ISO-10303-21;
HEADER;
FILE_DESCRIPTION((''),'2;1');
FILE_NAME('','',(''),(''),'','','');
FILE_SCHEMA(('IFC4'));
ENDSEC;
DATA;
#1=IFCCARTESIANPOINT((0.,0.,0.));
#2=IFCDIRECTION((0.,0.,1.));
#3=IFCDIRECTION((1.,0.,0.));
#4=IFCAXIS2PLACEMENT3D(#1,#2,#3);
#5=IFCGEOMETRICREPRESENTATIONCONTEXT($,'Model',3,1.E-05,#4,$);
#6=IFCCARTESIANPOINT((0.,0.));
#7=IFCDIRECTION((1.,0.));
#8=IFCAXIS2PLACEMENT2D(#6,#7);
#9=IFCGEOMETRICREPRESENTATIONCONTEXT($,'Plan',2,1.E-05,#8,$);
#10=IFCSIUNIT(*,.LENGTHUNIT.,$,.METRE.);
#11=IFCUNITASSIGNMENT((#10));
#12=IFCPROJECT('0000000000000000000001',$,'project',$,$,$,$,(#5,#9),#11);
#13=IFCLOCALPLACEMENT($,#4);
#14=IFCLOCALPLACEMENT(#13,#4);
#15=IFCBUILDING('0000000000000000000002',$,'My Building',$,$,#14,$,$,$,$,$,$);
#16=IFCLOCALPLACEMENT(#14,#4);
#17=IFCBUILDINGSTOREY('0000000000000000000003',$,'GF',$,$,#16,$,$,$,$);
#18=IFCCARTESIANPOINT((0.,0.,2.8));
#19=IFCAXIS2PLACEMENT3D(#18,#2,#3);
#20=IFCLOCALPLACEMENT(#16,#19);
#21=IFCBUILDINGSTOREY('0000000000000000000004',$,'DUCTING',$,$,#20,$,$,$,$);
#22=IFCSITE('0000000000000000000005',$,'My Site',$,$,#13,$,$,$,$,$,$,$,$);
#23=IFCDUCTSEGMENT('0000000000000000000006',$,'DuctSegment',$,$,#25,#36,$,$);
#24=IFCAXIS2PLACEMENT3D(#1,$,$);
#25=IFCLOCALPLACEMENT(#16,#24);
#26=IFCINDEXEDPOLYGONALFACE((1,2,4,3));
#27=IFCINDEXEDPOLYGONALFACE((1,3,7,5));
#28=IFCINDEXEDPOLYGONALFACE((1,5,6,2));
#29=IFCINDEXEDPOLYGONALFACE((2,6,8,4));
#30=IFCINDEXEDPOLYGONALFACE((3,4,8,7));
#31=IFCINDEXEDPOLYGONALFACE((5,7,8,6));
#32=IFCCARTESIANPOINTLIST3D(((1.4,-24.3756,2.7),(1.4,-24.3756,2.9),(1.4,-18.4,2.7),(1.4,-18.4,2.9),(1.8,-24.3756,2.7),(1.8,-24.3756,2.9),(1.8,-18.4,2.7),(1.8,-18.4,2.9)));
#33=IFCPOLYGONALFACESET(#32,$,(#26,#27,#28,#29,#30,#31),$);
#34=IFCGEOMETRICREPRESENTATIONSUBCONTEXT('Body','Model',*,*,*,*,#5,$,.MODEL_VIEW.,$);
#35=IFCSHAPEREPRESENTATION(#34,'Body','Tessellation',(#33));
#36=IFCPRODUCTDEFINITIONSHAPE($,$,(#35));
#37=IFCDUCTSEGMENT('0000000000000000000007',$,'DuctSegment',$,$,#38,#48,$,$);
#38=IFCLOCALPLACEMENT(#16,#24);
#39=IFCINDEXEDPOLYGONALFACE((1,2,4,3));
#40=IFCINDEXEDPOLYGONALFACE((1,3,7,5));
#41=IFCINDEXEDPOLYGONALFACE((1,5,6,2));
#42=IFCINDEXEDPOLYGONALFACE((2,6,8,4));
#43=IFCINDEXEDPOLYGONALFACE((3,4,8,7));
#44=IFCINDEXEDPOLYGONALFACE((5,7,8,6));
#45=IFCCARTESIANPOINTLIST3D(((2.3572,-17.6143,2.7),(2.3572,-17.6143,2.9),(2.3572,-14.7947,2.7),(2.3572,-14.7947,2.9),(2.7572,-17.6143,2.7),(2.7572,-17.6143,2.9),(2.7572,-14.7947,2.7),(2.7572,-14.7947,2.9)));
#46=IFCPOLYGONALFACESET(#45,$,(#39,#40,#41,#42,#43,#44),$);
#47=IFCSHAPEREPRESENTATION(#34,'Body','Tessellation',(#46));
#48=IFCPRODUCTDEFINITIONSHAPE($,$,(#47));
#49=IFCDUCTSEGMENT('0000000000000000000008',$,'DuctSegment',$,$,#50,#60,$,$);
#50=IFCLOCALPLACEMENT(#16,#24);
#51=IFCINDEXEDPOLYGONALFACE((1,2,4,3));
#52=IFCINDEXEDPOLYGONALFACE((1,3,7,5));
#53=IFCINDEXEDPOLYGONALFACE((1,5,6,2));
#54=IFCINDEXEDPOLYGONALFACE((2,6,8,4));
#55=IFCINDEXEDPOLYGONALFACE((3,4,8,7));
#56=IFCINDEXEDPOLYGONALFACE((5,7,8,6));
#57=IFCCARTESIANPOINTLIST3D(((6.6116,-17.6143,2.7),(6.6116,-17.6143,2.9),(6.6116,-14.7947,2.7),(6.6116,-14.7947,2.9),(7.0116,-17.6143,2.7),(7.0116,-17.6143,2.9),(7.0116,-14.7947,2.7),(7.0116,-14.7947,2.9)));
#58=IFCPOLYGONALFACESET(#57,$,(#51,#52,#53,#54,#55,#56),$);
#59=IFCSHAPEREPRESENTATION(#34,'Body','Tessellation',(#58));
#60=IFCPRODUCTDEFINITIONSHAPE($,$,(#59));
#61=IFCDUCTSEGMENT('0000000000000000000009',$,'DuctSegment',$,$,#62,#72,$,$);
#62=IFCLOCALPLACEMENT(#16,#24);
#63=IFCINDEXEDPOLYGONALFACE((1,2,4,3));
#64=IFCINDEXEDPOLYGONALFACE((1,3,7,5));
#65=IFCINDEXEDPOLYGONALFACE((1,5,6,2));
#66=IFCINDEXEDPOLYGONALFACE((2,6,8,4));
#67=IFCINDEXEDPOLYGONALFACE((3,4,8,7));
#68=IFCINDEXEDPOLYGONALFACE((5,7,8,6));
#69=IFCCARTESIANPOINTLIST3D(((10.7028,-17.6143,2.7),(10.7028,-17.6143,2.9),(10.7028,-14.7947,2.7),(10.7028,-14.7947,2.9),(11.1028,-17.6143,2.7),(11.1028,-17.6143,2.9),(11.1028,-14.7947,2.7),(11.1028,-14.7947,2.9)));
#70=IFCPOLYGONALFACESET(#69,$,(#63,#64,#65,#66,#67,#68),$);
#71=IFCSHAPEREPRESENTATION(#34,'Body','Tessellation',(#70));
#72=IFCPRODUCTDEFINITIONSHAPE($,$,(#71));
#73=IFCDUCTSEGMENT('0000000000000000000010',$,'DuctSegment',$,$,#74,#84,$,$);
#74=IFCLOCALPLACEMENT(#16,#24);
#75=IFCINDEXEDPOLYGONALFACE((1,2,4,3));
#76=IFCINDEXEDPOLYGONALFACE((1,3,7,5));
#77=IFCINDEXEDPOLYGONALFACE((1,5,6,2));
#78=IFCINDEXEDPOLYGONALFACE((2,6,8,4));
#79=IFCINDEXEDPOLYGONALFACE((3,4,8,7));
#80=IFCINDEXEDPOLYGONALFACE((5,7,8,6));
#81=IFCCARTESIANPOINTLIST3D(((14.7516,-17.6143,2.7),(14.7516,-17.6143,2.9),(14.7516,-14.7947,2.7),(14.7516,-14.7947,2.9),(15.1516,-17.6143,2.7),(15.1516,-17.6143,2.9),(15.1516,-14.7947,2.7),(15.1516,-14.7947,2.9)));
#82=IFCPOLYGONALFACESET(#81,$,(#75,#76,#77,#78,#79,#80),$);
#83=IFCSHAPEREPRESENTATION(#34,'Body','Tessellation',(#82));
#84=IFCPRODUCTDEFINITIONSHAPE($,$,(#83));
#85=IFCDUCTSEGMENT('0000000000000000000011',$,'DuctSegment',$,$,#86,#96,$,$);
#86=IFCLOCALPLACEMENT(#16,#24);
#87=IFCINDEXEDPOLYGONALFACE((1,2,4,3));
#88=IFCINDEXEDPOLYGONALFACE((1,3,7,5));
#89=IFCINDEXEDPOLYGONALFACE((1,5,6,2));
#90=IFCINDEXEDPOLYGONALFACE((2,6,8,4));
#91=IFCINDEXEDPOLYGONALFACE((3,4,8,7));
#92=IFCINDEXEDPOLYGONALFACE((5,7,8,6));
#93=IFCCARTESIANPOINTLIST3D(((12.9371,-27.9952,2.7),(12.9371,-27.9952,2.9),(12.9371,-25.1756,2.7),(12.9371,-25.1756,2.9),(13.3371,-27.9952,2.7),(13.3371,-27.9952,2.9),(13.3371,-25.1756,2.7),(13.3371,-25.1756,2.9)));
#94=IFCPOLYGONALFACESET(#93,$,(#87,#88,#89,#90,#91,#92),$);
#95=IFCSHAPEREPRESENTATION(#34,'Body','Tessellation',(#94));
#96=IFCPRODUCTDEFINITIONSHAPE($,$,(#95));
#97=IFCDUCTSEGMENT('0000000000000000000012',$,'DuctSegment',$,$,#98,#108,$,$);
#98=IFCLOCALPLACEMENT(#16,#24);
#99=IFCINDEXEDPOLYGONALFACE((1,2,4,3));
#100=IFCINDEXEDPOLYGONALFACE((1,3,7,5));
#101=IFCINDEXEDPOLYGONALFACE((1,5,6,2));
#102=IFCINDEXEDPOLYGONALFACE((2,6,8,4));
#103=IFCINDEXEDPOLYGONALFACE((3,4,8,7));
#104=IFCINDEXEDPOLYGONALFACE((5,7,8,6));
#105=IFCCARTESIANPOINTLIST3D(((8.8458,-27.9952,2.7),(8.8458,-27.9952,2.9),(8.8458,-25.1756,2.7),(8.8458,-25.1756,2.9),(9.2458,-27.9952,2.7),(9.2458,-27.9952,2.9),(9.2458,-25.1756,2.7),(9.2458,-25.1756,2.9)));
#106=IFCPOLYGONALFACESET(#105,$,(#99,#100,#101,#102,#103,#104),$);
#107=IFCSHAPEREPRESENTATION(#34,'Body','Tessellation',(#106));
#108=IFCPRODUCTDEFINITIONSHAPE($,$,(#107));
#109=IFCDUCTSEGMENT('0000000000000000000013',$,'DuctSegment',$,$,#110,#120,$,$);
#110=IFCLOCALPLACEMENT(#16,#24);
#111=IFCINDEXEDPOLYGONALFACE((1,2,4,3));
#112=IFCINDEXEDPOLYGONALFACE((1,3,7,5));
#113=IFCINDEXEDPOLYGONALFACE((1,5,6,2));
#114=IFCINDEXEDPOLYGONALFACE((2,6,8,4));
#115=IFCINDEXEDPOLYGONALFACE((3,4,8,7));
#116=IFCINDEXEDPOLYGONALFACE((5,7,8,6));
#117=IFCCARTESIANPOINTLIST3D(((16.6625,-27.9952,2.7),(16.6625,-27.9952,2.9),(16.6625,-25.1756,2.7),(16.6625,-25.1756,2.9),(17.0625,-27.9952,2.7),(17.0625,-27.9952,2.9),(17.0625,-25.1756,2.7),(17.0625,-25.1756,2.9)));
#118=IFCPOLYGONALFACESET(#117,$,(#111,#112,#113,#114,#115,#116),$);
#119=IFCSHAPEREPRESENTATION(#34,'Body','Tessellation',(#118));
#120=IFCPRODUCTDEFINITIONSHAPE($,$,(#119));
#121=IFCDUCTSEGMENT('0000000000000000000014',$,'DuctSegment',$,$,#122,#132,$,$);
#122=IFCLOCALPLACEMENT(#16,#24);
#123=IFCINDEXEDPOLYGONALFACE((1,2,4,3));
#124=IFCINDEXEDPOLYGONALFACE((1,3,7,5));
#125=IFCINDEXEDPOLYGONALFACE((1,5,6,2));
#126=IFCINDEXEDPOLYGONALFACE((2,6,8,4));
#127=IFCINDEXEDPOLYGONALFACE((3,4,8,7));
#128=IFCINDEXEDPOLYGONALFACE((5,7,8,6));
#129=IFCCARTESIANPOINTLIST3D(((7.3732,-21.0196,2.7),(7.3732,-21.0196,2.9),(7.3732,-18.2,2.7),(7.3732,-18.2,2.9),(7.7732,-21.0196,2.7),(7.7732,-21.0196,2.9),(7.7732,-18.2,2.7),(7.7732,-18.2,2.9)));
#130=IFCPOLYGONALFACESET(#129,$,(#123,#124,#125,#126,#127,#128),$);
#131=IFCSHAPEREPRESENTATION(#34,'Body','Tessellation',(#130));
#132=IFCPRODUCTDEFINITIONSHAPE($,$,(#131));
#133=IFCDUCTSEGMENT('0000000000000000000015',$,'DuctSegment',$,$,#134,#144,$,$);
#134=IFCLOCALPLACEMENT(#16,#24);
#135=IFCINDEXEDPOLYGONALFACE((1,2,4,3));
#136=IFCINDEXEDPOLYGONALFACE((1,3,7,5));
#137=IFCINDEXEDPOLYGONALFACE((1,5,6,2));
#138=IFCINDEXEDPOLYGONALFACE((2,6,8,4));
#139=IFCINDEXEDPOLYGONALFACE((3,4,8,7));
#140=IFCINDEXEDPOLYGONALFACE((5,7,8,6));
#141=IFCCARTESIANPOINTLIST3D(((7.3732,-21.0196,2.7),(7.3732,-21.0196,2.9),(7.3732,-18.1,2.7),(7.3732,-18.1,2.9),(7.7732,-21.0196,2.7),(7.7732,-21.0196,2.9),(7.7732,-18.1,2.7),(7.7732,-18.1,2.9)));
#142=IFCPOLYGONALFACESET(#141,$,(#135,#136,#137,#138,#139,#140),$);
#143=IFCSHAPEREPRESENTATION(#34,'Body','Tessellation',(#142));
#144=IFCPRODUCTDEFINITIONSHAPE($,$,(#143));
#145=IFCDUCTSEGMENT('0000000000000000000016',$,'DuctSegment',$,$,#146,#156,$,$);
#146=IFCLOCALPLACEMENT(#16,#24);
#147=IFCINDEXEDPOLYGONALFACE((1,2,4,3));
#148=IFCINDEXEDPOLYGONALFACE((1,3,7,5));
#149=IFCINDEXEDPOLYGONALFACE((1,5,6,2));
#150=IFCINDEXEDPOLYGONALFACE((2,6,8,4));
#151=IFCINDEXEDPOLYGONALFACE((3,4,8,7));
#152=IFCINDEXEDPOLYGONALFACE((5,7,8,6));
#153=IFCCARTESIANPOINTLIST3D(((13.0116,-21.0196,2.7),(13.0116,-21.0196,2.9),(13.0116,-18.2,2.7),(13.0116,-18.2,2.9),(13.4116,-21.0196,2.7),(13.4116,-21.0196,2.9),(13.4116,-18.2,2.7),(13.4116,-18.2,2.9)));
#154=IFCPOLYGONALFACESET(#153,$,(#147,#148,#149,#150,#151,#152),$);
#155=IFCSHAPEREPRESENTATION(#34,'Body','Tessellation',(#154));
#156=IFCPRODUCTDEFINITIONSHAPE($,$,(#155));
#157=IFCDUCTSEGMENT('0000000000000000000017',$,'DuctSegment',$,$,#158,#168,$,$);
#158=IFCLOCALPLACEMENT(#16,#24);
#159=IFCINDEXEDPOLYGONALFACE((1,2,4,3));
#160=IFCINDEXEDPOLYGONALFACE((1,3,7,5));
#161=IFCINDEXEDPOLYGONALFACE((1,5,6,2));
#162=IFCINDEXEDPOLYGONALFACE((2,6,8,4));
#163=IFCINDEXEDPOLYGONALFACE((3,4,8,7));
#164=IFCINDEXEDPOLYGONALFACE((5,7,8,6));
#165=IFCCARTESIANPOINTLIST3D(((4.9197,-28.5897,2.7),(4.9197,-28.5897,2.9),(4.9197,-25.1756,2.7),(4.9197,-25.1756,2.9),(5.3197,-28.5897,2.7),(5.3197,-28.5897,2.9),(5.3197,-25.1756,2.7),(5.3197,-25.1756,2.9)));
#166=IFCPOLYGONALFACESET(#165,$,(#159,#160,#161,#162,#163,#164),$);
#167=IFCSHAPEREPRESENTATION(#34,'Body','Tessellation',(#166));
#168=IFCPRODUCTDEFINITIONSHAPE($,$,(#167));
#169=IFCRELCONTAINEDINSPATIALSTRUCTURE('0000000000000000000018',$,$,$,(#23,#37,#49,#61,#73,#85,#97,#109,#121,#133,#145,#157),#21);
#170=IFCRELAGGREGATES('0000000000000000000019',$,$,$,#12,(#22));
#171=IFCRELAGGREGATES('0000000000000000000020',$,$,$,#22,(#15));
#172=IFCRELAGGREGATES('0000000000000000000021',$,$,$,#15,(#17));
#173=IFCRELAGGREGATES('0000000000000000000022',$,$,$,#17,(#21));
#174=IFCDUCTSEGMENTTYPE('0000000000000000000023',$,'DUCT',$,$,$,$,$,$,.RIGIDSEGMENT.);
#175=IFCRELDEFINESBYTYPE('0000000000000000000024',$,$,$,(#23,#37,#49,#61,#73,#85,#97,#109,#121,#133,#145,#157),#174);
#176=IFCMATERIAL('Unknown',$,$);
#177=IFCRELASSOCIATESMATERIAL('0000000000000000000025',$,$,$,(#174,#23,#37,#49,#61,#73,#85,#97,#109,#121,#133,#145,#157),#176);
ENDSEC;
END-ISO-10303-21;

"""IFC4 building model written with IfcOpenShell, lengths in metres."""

from ifc_helpers import new_model, si_unit, frame, origin_with_axes, origin_2d_with_axis, place, context, subcontext, project, spatial, rectangle, extrude, material, material_profile, profile_set, profile_usage, type_object, element, save


model = new_model("IFC4")

# Units and contexts
model_context = context("Model", 3, precision=1e-05, world=origin_with_axes())
plan_context = context("Plan", 2, precision=1e-05, world=origin_2d_with_axis())
body_context = subcontext(model_context, "Body", "Model", "MODEL_VIEW")
ifc_project = project(units=[si_unit("LENGTHUNIT", "METRE")], contexts=[model_context, plan_context])

# Site, building, storeys
site_placement = place(None, origin_with_axes())
site = spatial("IfcSite", under=ifc_project, at=site_placement, Name="My Site")
building_placement = place(site_placement, origin_with_axes())
building = spatial("IfcBuilding", under=site, at=building_placement, Name="My Building")
storey_1_placement = place(building_placement, origin_with_axes())
storey_1 = spatial("IfcBuildingStorey", under=building, at=storey_1_placement, Name="GF")
storey_2_placement = place(storey_1_placement, frame((0.0, 0.0, 2.8), z_axis=(0.0, 0.0, 1.0), x_axis=(1.0, 0.0, 0.0)))
storey_2 = spatial("IfcBuildingStorey", under=storey_1, at=storey_2_placement, Name="DUCTING")

# Duct segments
ifc_material = material(Name="Unknown")
ifc_material_profile_1 = material_profile(ifc_material, rectangle(XDim=0.4, YDim=0.2))
ifc_profile_set_1 = profile_set([ifc_material_profile_1])
ifc_profile_usage_1 = profile_usage(ifc_profile_set_1, cardinal=5)
duct_segment_type = type_object("IfcDuctSegmentType", Name="DUCT", PredefinedType="RIGIDSEGMENT", material=ifc_profile_set_1)
duct_segment_1_placement = place(storey_2_placement, frame((1.6, -18.4, 0.0), z_axis=(0.0, -1.0, 0.0), x_axis=(1.0, 0.0, 0.0)))
element("IfcDuctSegment", 1, at=duct_segment_1_placement, inside=storey_2, type_object=duct_segment_type, material=ifc_profile_usage_1, Name="DuctSegment", context=body_context, shape_type="SweptSolid", body=[
    extrude(rectangle(XDim=0.4, YDim=0.2), origin_with_axes(), (0.0, 0.0, 1.0), 5.9756),
])
ifc_profile_usage_2 = profile_usage(ifc_profile_set_1, cardinal=5)
duct_segment_2_placement = place(storey_2_placement, frame((2.5572, -17.6143, 0.0), z_axis=(0.0, 1.0, 0.0), x_axis=(-1.0, 0.0, 0.0)))
element("IfcDuctSegment", 2, at=duct_segment_2_placement, inside=storey_2, type_object=duct_segment_type, material=ifc_profile_usage_2, Name="DuctSegment", context=body_context, shape_type="SweptSolid", body=[
    extrude(rectangle(XDim=0.4, YDim=0.2), origin_with_axes(), (0.0, 0.0, 1.0), 2.8196),
])
ifc_profile_usage_3 = profile_usage(ifc_profile_set_1, cardinal=5)
duct_segment_3_placement = place(storey_2_placement, frame((6.8116, -17.6143, 0.0), z_axis=(0.0, 1.0, 0.0), x_axis=(-1.0, 0.0, 0.0)))
element("IfcDuctSegment", 3, at=duct_segment_3_placement, inside=storey_2, type_object=duct_segment_type, material=ifc_profile_usage_3, Name="DuctSegment", context=body_context, shape_type="SweptSolid", body=[
    extrude(rectangle(XDim=0.4, YDim=0.2), origin_with_axes(), (0.0, 0.0, 1.0), 2.8196),
])
ifc_profile_usage_4 = profile_usage(ifc_profile_set_1, cardinal=5)
duct_segment_4_placement = place(storey_2_placement, frame((10.9028, -17.6143, 0.0), z_axis=(0.0, 1.0, 0.0), x_axis=(-1.0, 0.0, 0.0)))
element("IfcDuctSegment", 4, at=duct_segment_4_placement, inside=storey_2, type_object=duct_segment_type, material=ifc_profile_usage_4, Name="DuctSegment", context=body_context, shape_type="SweptSolid", body=[
    extrude(rectangle(XDim=0.4, YDim=0.2), origin_with_axes(), (0.0, 0.0, 1.0), 2.8196),
])
ifc_profile_usage_5 = profile_usage(ifc_profile_set_1, cardinal=5)
duct_segment_5_placement = place(storey_2_placement, frame((14.9516, -17.6143, 0.0), z_axis=(0.0, 1.0, 0.0), x_axis=(-1.0, 0.0, 0.0)))
element("IfcDuctSegment", 5, at=duct_segment_5_placement, inside=storey_2, type_object=duct_segment_type, material=ifc_profile_usage_5, Name="DuctSegment", context=body_context, shape_type="SweptSolid", body=[
    extrude(rectangle(XDim=0.4, YDim=0.2), origin_with_axes(), (0.0, 0.0, 1.0), 2.8196),
])
ifc_profile_usage_6 = profile_usage(ifc_profile_set_1, cardinal=5)
duct_segment_6_placement = place(storey_2_placement, frame((13.1371, -27.9952, 0.0), z_axis=(0.0, 1.0, 0.0), x_axis=(-1.0, 0.0, 0.0)))
element("IfcDuctSegment", 6, at=duct_segment_6_placement, inside=storey_2, type_object=duct_segment_type, material=ifc_profile_usage_6, Name="DuctSegment", context=body_context, shape_type="SweptSolid", body=[
    extrude(rectangle(XDim=0.4, YDim=0.2), origin_with_axes(), (0.0, 0.0, 1.0), 2.8196),
])
ifc_profile_usage_7 = profile_usage(ifc_profile_set_1, cardinal=5)
duct_segment_7_placement = place(storey_2_placement, frame((9.0458, -27.9952, 0.0), z_axis=(0.0, 1.0, 0.0), x_axis=(-1.0, 0.0, 0.0)))
element("IfcDuctSegment", 7, at=duct_segment_7_placement, inside=storey_2, type_object=duct_segment_type, material=ifc_profile_usage_7, Name="DuctSegment", context=body_context, shape_type="SweptSolid", body=[
    extrude(rectangle(XDim=0.4, YDim=0.2), origin_with_axes(), (0.0, 0.0, 1.0), 2.8196),
])
ifc_profile_usage_8 = profile_usage(ifc_profile_set_1, cardinal=5)
duct_segment_8_placement = place(storey_2_placement, frame((16.8625, -27.9952, 0.0), z_axis=(0.0, 1.0, 0.0), x_axis=(-1.0, 0.0, 0.0)))
element("IfcDuctSegment", 8, at=duct_segment_8_placement, inside=storey_2, type_object=duct_segment_type, material=ifc_profile_usage_8, Name="DuctSegment", context=body_context, shape_type="SweptSolid", body=[
    extrude(rectangle(XDim=0.4, YDim=0.2), origin_with_axes(), (0.0, 0.0, 1.0), 2.8196),
])
ifc_profile_usage_9 = profile_usage(ifc_profile_set_1, cardinal=5)
duct_segment_9_placement = place(storey_2_placement, frame((7.5732, -21.0196, 0.0), z_axis=(0.0, 1.0, 0.0), x_axis=(-1.0, 0.0, 0.0)))
element("IfcDuctSegment", 9, at=duct_segment_9_placement, inside=storey_2, type_object=duct_segment_type, material=ifc_profile_usage_9, Name="DuctSegment", context=body_context, shape_type="SweptSolid", body=[
    extrude(rectangle(XDim=0.4, YDim=0.2), origin_with_axes(), (0.0, 0.0, 1.0), 2.8196),
])
ifc_profile_usage_10 = profile_usage(ifc_profile_set_1, cardinal=5)
duct_segment_10_placement = place(storey_2_placement, frame((7.5732, -21.0196, 0.0), z_axis=(0.0, 1.0, 0.0), x_axis=(-1.0, 0.0, 0.0)))
element("IfcDuctSegment", 10, at=duct_segment_10_placement, inside=storey_2, type_object=duct_segment_type, material=ifc_profile_usage_10, Name="DuctSegment", context=body_context, shape_type="SweptSolid", body=[
    extrude(rectangle(XDim=0.4, YDim=0.2), origin_with_axes(), (0.0, 0.0, 1.0), 2.9196),
])
ifc_profile_usage_11 = profile_usage(ifc_profile_set_1, cardinal=5)
duct_segment_11_placement = place(storey_2_placement, frame((13.2116, -21.0196, 0.0), z_axis=(0.0, 1.0, 0.0), x_axis=(-1.0, 0.0, 0.0)))
element("IfcDuctSegment", 11, at=duct_segment_11_placement, inside=storey_2, type_object=duct_segment_type, material=ifc_profile_usage_11, Name="DuctSegment", context=body_context, shape_type="SweptSolid", body=[
    extrude(rectangle(XDim=0.4, YDim=0.2), origin_with_axes(), (0.0, 0.0, 1.0), 2.8196),
])
ifc_profile_usage_12 = profile_usage(ifc_profile_set_1, cardinal=5)
duct_segment_12_placement = place(storey_2_placement, frame((5.1197, -28.5897, 0.0), z_axis=(0.0, 1.0, 0.0), x_axis=(-1.0, 0.0, 0.0)))
element("IfcDuctSegment", 12, at=duct_segment_12_placement, inside=storey_2, type_object=duct_segment_type, material=ifc_profile_usage_12, Name="DuctSegment", context=body_context, shape_type="SweptSolid", body=[
    extrude(rectangle(XDim=0.4, YDim=0.2), origin_with_axes(), (0.0, 0.0, 1.0), 3.4141),
])

save(model, "model.ifc")
